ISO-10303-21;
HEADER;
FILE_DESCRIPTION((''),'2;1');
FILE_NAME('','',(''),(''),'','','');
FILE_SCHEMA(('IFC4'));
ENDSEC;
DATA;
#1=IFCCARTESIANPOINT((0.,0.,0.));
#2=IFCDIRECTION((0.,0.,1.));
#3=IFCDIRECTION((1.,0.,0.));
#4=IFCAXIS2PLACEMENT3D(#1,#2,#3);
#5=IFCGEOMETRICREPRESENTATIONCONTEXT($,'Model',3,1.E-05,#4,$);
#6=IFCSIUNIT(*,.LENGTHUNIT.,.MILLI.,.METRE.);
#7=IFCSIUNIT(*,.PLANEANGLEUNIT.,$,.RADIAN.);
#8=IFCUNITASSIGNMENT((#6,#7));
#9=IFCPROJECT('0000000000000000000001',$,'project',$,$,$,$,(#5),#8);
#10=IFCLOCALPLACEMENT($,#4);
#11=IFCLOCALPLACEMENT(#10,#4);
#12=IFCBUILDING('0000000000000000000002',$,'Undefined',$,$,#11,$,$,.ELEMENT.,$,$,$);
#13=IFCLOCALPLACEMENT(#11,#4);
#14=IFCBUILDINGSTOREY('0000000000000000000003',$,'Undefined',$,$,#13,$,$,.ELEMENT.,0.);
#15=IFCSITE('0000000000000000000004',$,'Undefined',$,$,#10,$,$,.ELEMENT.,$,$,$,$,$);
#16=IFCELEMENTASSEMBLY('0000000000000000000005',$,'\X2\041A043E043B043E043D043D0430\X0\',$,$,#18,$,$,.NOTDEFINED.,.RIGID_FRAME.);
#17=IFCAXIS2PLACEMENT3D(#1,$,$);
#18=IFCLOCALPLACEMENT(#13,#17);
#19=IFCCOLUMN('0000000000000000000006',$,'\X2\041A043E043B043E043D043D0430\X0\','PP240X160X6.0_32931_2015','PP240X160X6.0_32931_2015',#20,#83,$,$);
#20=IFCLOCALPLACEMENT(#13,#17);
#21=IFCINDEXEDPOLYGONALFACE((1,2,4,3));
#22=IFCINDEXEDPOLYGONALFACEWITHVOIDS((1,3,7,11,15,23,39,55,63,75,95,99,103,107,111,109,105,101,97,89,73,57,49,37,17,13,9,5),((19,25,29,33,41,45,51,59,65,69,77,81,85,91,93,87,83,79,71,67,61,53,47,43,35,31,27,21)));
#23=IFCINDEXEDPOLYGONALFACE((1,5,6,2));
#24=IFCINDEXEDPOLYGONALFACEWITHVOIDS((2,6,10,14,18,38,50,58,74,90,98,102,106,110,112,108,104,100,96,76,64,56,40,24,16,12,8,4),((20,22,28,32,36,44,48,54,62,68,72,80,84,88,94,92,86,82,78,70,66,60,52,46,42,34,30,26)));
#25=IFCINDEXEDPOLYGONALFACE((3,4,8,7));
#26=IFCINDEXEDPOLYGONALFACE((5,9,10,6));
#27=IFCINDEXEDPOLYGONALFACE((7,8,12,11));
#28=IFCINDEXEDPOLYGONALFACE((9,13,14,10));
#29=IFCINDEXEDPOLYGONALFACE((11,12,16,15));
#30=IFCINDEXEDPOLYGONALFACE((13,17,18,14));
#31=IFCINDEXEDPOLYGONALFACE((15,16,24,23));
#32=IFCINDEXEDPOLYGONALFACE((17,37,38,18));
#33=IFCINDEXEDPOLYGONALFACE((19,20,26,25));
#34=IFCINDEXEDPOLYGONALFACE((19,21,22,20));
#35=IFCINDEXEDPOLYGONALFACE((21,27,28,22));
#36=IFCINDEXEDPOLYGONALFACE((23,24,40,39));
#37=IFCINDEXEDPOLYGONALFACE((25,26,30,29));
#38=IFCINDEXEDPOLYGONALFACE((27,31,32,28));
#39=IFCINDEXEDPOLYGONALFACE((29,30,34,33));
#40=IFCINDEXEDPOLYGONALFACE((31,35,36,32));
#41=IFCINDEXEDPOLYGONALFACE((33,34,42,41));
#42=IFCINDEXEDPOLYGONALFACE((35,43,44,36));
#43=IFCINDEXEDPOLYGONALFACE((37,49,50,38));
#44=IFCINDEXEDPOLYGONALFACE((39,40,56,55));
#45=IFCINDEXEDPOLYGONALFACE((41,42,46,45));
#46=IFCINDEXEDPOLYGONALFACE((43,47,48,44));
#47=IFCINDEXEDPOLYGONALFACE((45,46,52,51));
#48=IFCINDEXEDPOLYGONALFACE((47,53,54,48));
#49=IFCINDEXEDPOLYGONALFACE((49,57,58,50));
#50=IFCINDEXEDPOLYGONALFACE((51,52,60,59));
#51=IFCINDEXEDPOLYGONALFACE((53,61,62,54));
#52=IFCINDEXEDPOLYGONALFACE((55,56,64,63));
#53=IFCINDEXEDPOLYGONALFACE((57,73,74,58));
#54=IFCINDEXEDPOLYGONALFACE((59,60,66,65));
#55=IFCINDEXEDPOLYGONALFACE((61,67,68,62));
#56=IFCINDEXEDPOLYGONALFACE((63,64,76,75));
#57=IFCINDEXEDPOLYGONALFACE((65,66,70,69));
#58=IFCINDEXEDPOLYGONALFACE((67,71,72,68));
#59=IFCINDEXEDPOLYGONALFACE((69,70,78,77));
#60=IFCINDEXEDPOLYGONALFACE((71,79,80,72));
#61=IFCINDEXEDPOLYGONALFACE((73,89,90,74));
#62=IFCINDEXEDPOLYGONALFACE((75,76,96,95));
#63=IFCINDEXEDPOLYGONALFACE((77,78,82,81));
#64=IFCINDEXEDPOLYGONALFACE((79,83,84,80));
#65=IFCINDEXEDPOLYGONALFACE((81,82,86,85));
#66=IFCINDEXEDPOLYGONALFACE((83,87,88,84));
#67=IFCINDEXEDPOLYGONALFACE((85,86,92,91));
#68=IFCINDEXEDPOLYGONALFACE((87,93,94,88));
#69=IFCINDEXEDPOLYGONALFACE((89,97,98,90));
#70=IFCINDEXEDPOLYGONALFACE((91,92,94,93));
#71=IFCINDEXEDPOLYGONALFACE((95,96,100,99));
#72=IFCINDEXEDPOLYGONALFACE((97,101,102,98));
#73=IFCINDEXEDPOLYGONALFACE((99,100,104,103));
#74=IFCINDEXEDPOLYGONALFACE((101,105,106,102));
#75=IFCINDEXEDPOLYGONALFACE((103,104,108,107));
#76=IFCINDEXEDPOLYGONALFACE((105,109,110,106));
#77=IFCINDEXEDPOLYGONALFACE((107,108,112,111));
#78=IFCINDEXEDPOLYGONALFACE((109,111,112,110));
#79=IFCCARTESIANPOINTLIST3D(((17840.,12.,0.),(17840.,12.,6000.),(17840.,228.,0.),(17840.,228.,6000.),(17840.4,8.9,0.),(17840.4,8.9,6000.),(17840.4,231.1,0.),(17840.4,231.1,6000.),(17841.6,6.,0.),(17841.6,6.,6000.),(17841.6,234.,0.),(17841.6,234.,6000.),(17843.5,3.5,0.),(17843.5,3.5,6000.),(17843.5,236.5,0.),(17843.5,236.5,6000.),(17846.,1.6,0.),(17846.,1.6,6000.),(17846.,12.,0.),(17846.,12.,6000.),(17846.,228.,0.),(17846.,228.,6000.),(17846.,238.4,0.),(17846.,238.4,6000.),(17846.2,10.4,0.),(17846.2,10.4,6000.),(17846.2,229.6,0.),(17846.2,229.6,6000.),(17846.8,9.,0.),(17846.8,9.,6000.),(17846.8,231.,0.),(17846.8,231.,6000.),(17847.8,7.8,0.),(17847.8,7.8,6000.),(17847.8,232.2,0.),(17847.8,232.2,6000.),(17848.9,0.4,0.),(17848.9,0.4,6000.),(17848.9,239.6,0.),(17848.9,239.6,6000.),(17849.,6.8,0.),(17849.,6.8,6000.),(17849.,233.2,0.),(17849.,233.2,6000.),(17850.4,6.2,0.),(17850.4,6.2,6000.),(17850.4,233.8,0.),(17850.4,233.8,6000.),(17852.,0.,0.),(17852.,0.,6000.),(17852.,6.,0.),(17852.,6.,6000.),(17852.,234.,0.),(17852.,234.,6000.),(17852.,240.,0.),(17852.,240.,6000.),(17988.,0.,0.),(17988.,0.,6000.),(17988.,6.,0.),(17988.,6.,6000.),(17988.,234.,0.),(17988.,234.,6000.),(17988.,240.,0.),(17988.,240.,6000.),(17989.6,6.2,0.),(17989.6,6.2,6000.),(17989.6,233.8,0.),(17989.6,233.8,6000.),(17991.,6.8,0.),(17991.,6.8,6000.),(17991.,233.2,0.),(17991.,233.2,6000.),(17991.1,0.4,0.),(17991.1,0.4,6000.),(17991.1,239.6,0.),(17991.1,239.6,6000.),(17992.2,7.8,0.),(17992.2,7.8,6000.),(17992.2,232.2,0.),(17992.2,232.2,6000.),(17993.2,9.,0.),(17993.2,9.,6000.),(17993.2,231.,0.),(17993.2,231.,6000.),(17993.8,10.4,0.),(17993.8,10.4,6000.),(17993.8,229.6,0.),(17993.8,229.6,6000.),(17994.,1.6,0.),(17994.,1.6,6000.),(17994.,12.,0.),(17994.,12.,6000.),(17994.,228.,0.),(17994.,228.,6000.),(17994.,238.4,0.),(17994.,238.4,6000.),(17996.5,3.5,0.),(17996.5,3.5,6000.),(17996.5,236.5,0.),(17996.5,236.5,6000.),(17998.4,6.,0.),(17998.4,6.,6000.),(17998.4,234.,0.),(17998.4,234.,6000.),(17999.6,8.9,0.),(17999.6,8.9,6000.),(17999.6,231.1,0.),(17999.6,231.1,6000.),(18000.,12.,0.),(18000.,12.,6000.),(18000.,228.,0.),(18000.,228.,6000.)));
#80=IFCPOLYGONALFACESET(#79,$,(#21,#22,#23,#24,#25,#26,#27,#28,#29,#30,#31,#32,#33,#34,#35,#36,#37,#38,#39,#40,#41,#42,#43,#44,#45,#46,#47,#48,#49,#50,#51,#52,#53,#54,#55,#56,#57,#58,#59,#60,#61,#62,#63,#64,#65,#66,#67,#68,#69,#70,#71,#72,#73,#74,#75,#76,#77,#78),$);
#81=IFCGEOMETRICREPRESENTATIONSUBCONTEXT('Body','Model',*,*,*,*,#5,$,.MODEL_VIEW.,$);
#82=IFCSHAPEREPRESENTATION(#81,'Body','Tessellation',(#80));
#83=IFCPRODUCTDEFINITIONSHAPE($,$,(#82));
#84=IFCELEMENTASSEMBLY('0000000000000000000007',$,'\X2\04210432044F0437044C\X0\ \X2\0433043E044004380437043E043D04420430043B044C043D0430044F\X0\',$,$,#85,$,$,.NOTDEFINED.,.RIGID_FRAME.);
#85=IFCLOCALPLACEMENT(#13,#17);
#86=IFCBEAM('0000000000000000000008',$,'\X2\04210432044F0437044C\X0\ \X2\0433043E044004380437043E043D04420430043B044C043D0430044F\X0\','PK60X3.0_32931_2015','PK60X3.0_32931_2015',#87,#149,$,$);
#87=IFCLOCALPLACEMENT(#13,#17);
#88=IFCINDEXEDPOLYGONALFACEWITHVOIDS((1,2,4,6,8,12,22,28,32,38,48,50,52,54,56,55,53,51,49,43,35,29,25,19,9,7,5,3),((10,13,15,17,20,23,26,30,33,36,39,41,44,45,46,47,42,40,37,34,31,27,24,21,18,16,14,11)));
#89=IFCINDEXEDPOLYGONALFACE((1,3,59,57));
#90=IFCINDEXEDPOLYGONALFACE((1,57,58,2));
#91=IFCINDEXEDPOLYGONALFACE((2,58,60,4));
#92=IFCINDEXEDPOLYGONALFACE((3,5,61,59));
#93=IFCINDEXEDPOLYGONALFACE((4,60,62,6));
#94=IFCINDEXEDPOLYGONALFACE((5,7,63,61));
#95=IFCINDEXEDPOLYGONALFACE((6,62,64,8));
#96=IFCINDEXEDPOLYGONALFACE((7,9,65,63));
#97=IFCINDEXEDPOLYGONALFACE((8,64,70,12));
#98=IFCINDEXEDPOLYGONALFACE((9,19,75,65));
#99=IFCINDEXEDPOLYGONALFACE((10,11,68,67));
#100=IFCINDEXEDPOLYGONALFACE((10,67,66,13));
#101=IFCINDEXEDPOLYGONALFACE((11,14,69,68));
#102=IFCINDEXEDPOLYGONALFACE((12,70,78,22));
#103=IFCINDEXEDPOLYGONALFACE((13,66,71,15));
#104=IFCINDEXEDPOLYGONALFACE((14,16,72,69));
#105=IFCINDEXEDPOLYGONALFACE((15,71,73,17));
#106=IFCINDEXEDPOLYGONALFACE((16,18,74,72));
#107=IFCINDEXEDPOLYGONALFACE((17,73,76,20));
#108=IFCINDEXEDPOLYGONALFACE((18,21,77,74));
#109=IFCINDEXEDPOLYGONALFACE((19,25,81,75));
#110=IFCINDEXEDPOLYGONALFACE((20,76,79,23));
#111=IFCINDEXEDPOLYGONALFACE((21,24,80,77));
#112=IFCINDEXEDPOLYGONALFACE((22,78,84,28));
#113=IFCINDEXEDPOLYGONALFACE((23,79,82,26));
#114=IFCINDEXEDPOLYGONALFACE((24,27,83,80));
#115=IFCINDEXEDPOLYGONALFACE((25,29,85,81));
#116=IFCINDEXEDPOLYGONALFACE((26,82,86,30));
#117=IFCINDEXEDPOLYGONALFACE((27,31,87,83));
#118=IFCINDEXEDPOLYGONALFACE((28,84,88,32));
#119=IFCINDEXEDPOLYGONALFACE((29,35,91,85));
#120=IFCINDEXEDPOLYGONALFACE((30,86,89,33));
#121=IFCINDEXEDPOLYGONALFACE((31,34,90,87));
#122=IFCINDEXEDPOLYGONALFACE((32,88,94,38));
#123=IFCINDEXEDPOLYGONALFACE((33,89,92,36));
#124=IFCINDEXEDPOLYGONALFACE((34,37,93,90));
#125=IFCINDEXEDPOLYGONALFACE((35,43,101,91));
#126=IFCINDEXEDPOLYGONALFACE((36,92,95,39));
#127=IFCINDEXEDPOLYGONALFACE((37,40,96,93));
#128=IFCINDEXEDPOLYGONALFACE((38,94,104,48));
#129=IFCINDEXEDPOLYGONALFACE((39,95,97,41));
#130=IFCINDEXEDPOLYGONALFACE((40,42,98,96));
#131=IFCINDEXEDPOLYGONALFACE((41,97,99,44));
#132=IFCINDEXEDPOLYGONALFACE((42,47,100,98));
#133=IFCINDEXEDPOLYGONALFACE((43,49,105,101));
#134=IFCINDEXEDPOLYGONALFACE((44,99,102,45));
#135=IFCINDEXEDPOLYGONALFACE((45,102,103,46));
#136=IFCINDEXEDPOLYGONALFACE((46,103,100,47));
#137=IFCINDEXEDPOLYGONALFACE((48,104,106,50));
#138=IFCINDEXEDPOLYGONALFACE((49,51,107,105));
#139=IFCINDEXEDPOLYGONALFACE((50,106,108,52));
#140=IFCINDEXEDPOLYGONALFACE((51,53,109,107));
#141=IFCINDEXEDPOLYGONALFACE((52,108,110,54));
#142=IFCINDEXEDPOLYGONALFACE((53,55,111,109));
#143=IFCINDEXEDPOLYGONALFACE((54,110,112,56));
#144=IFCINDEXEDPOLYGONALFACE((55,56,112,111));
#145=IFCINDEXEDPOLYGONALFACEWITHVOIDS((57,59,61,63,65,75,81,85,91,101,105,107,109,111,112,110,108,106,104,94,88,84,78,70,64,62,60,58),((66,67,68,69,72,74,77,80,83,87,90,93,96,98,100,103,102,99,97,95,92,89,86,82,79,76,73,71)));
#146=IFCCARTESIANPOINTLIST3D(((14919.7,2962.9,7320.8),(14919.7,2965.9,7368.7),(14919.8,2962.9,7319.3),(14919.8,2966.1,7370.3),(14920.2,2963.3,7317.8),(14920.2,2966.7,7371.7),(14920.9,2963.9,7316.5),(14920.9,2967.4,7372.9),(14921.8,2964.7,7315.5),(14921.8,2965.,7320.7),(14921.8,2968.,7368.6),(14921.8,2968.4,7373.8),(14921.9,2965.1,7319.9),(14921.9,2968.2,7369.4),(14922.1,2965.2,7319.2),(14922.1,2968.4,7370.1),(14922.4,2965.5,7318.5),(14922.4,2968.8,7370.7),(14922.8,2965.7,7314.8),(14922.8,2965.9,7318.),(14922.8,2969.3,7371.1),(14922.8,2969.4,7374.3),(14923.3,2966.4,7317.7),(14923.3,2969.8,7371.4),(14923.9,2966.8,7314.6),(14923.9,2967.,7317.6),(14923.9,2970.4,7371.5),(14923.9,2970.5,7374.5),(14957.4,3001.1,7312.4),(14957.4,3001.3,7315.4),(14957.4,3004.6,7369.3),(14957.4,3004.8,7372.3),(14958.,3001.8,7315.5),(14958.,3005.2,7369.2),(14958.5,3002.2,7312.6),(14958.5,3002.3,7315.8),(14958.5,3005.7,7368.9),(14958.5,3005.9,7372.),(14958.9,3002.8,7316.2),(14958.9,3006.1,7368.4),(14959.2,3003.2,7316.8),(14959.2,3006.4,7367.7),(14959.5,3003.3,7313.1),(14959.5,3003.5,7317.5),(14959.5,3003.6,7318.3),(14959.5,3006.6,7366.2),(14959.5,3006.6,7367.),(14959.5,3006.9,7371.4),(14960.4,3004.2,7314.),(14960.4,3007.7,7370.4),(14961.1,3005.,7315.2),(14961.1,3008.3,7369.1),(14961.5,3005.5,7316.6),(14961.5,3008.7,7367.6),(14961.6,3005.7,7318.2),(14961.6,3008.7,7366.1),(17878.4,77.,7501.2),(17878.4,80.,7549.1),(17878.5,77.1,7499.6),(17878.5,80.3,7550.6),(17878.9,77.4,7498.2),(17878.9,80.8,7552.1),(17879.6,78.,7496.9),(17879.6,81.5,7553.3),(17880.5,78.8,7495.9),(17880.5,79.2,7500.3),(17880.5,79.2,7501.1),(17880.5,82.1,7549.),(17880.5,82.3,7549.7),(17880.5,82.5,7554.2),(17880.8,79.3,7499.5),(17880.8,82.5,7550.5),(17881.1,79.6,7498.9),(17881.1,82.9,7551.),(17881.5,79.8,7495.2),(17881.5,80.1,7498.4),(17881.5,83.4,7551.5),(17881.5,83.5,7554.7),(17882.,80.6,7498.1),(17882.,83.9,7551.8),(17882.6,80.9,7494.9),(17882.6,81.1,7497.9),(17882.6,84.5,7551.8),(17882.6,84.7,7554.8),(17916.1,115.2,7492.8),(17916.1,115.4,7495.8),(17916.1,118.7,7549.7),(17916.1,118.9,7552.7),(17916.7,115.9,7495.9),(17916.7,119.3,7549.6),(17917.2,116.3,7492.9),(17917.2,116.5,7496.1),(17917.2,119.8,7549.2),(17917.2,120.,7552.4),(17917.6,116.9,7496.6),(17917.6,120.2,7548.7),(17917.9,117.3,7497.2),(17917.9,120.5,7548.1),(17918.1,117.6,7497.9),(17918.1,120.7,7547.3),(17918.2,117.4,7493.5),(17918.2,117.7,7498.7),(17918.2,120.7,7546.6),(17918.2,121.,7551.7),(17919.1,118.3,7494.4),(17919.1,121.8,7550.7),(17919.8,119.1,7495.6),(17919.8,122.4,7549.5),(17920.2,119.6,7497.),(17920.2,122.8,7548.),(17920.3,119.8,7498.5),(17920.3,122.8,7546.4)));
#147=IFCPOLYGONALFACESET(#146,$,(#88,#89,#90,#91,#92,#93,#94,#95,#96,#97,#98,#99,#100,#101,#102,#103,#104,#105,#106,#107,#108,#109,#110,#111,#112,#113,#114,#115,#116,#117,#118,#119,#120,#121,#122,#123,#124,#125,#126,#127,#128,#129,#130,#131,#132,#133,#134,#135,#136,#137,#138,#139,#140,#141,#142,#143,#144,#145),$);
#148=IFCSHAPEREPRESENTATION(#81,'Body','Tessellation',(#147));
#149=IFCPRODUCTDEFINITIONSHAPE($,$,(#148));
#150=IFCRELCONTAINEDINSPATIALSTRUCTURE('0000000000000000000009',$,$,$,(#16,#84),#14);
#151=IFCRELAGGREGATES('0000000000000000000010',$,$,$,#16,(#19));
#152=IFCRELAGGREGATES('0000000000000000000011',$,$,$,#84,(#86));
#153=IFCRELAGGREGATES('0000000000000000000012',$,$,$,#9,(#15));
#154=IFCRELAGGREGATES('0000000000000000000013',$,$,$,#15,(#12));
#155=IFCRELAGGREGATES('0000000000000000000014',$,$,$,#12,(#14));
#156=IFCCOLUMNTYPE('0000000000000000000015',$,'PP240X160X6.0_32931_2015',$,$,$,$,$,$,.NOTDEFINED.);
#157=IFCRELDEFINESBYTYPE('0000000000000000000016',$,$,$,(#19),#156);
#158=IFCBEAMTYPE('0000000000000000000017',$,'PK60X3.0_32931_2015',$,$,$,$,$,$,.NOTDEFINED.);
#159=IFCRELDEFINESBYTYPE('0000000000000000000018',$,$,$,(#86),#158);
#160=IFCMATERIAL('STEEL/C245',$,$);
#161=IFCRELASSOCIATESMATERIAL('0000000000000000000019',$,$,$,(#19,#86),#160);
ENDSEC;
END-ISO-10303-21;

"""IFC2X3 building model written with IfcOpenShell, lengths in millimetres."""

from ifc_helpers import new_model, si_unit, frame, origin_with_axes, origin_2d_with_axis, place, context, subcontext, project, spatial, hollow_rectangle, extrude, material, type_object, element, aggregate, save


model = new_model("IFC2X3")

# Units and contexts
model_context = context("Model", 3, precision=1e-05, world=origin_with_axes())
body_context = subcontext(model_context, "Body", "Model", "MODEL_VIEW")
ifc_project = project(units=[si_unit("LENGTHUNIT", "METRE", prefix="MILLI"), si_unit("PLANEANGLEUNIT", "RADIAN")], contexts=[model_context])

# Site, building, storey
site_placement = place(None, origin_with_axes())
site = spatial("IfcSite", under=ifc_project, at=site_placement, Name="Undefined", CompositionType="ELEMENT")
building_placement = place(site_placement, origin_with_axes())
building = spatial("IfcBuilding", under=site, at=building_placement, Name="Undefined", CompositionType="ELEMENT")
storey_placement = place(building_placement, origin_with_axes())
storey = spatial("IfcBuildingStorey", under=building, at=storey_placement, Name="Undefined", CompositionType="ELEMENT", Elevation=0.0)

# Element assembly, column
assembly_1_placement = place(storey_placement, origin_with_axes())
assembly_1 = element("IfcElementAssembly", 1, at=assembly_1_placement, inside=storey, Name="Колонна", AssemblyPlace="NOTDEFINED", PredefinedType="RIGID_FRAME")
ifc_material = material(Name="STEEL/C245")
column_type = type_object("IfcColumnType", Name="PP240X160X6.0_32931_2015", PredefinedType="NOTDEFINED")
column_placement = place(assembly_1_placement, frame((17920.0, 120.0, 0.0), z_axis=(0.0, 0.0, 1.0), x_axis=(0.0, 1.0, 0.0)))
column = element("IfcColumn", 2, at=column_placement, type_object=column_type, material=ifc_material, Name="Колонна", Description="PP240X160X6.0_32931_2015", ObjectType="PP240X160X6.0_32931_2015", context=body_context, shape_type="SweptSolid", body=[
    extrude(hollow_rectangle(XDim=160.0, YDim=240.0, WallThickness=6.0, InnerFilletRadius=6.0, OuterFilletRadius=12.0, at=origin_2d_with_axis()), frame((0.0, 0.0, 6000.0), z_axis=(0.0, 0.0, -1.0), x_axis=(0.0, 1.0, 0.0)), (0.0, 0.0, 1.0), 6000.0),
])
aggregate(assembly_1, [column])

# Element assembly, beam
assembly_2_placement = place(storey_placement, origin_with_axes())
assembly_2 = element("IfcElementAssembly", 3, at=assembly_2_placement, inside=storey, Name="Связь горизонтальная", AssemblyPlace="NOTDEFINED", PredefinedType="RIGID_FRAME")
beam_type_1 = type_object("IfcBeamType", Name="PK60X3.0_32931_2015", PredefinedType="NOTDEFINED")
beam_1_placement = place(assembly_2_placement, frame((17899.3, 99.9, 7523.8), z_axis=(0.0, 0.062378, 0.998053), x_axis=(-0.715179, 0.69758, -0.043599)))
beam_1 = element("IfcBeam", 4, at=beam_1_placement, type_object=beam_type_1, material=ifc_material, Name="Связь горизонтальная", Description="PK60X3.0_32931_2015", ObjectType="PK60X3.0_32931_2015", context=body_context, shape_type="SweptSolid", body=[
    extrude(hollow_rectangle(XDim=60.0, YDim=60.0, WallThickness=3.0, InnerFilletRadius=3.0, OuterFilletRadius=6.0, at=origin_2d_with_axis()), frame((4137.0, 0.0, 0.0), z_axis=(-1.0, 0.0, 0.0), x_axis=(0.0, -1.0, 0.0)), (0.0, 0.0, 1.0), 4137.0),
])
aggregate(assembly_2, [beam_1])

save(model, "model.ifc")
